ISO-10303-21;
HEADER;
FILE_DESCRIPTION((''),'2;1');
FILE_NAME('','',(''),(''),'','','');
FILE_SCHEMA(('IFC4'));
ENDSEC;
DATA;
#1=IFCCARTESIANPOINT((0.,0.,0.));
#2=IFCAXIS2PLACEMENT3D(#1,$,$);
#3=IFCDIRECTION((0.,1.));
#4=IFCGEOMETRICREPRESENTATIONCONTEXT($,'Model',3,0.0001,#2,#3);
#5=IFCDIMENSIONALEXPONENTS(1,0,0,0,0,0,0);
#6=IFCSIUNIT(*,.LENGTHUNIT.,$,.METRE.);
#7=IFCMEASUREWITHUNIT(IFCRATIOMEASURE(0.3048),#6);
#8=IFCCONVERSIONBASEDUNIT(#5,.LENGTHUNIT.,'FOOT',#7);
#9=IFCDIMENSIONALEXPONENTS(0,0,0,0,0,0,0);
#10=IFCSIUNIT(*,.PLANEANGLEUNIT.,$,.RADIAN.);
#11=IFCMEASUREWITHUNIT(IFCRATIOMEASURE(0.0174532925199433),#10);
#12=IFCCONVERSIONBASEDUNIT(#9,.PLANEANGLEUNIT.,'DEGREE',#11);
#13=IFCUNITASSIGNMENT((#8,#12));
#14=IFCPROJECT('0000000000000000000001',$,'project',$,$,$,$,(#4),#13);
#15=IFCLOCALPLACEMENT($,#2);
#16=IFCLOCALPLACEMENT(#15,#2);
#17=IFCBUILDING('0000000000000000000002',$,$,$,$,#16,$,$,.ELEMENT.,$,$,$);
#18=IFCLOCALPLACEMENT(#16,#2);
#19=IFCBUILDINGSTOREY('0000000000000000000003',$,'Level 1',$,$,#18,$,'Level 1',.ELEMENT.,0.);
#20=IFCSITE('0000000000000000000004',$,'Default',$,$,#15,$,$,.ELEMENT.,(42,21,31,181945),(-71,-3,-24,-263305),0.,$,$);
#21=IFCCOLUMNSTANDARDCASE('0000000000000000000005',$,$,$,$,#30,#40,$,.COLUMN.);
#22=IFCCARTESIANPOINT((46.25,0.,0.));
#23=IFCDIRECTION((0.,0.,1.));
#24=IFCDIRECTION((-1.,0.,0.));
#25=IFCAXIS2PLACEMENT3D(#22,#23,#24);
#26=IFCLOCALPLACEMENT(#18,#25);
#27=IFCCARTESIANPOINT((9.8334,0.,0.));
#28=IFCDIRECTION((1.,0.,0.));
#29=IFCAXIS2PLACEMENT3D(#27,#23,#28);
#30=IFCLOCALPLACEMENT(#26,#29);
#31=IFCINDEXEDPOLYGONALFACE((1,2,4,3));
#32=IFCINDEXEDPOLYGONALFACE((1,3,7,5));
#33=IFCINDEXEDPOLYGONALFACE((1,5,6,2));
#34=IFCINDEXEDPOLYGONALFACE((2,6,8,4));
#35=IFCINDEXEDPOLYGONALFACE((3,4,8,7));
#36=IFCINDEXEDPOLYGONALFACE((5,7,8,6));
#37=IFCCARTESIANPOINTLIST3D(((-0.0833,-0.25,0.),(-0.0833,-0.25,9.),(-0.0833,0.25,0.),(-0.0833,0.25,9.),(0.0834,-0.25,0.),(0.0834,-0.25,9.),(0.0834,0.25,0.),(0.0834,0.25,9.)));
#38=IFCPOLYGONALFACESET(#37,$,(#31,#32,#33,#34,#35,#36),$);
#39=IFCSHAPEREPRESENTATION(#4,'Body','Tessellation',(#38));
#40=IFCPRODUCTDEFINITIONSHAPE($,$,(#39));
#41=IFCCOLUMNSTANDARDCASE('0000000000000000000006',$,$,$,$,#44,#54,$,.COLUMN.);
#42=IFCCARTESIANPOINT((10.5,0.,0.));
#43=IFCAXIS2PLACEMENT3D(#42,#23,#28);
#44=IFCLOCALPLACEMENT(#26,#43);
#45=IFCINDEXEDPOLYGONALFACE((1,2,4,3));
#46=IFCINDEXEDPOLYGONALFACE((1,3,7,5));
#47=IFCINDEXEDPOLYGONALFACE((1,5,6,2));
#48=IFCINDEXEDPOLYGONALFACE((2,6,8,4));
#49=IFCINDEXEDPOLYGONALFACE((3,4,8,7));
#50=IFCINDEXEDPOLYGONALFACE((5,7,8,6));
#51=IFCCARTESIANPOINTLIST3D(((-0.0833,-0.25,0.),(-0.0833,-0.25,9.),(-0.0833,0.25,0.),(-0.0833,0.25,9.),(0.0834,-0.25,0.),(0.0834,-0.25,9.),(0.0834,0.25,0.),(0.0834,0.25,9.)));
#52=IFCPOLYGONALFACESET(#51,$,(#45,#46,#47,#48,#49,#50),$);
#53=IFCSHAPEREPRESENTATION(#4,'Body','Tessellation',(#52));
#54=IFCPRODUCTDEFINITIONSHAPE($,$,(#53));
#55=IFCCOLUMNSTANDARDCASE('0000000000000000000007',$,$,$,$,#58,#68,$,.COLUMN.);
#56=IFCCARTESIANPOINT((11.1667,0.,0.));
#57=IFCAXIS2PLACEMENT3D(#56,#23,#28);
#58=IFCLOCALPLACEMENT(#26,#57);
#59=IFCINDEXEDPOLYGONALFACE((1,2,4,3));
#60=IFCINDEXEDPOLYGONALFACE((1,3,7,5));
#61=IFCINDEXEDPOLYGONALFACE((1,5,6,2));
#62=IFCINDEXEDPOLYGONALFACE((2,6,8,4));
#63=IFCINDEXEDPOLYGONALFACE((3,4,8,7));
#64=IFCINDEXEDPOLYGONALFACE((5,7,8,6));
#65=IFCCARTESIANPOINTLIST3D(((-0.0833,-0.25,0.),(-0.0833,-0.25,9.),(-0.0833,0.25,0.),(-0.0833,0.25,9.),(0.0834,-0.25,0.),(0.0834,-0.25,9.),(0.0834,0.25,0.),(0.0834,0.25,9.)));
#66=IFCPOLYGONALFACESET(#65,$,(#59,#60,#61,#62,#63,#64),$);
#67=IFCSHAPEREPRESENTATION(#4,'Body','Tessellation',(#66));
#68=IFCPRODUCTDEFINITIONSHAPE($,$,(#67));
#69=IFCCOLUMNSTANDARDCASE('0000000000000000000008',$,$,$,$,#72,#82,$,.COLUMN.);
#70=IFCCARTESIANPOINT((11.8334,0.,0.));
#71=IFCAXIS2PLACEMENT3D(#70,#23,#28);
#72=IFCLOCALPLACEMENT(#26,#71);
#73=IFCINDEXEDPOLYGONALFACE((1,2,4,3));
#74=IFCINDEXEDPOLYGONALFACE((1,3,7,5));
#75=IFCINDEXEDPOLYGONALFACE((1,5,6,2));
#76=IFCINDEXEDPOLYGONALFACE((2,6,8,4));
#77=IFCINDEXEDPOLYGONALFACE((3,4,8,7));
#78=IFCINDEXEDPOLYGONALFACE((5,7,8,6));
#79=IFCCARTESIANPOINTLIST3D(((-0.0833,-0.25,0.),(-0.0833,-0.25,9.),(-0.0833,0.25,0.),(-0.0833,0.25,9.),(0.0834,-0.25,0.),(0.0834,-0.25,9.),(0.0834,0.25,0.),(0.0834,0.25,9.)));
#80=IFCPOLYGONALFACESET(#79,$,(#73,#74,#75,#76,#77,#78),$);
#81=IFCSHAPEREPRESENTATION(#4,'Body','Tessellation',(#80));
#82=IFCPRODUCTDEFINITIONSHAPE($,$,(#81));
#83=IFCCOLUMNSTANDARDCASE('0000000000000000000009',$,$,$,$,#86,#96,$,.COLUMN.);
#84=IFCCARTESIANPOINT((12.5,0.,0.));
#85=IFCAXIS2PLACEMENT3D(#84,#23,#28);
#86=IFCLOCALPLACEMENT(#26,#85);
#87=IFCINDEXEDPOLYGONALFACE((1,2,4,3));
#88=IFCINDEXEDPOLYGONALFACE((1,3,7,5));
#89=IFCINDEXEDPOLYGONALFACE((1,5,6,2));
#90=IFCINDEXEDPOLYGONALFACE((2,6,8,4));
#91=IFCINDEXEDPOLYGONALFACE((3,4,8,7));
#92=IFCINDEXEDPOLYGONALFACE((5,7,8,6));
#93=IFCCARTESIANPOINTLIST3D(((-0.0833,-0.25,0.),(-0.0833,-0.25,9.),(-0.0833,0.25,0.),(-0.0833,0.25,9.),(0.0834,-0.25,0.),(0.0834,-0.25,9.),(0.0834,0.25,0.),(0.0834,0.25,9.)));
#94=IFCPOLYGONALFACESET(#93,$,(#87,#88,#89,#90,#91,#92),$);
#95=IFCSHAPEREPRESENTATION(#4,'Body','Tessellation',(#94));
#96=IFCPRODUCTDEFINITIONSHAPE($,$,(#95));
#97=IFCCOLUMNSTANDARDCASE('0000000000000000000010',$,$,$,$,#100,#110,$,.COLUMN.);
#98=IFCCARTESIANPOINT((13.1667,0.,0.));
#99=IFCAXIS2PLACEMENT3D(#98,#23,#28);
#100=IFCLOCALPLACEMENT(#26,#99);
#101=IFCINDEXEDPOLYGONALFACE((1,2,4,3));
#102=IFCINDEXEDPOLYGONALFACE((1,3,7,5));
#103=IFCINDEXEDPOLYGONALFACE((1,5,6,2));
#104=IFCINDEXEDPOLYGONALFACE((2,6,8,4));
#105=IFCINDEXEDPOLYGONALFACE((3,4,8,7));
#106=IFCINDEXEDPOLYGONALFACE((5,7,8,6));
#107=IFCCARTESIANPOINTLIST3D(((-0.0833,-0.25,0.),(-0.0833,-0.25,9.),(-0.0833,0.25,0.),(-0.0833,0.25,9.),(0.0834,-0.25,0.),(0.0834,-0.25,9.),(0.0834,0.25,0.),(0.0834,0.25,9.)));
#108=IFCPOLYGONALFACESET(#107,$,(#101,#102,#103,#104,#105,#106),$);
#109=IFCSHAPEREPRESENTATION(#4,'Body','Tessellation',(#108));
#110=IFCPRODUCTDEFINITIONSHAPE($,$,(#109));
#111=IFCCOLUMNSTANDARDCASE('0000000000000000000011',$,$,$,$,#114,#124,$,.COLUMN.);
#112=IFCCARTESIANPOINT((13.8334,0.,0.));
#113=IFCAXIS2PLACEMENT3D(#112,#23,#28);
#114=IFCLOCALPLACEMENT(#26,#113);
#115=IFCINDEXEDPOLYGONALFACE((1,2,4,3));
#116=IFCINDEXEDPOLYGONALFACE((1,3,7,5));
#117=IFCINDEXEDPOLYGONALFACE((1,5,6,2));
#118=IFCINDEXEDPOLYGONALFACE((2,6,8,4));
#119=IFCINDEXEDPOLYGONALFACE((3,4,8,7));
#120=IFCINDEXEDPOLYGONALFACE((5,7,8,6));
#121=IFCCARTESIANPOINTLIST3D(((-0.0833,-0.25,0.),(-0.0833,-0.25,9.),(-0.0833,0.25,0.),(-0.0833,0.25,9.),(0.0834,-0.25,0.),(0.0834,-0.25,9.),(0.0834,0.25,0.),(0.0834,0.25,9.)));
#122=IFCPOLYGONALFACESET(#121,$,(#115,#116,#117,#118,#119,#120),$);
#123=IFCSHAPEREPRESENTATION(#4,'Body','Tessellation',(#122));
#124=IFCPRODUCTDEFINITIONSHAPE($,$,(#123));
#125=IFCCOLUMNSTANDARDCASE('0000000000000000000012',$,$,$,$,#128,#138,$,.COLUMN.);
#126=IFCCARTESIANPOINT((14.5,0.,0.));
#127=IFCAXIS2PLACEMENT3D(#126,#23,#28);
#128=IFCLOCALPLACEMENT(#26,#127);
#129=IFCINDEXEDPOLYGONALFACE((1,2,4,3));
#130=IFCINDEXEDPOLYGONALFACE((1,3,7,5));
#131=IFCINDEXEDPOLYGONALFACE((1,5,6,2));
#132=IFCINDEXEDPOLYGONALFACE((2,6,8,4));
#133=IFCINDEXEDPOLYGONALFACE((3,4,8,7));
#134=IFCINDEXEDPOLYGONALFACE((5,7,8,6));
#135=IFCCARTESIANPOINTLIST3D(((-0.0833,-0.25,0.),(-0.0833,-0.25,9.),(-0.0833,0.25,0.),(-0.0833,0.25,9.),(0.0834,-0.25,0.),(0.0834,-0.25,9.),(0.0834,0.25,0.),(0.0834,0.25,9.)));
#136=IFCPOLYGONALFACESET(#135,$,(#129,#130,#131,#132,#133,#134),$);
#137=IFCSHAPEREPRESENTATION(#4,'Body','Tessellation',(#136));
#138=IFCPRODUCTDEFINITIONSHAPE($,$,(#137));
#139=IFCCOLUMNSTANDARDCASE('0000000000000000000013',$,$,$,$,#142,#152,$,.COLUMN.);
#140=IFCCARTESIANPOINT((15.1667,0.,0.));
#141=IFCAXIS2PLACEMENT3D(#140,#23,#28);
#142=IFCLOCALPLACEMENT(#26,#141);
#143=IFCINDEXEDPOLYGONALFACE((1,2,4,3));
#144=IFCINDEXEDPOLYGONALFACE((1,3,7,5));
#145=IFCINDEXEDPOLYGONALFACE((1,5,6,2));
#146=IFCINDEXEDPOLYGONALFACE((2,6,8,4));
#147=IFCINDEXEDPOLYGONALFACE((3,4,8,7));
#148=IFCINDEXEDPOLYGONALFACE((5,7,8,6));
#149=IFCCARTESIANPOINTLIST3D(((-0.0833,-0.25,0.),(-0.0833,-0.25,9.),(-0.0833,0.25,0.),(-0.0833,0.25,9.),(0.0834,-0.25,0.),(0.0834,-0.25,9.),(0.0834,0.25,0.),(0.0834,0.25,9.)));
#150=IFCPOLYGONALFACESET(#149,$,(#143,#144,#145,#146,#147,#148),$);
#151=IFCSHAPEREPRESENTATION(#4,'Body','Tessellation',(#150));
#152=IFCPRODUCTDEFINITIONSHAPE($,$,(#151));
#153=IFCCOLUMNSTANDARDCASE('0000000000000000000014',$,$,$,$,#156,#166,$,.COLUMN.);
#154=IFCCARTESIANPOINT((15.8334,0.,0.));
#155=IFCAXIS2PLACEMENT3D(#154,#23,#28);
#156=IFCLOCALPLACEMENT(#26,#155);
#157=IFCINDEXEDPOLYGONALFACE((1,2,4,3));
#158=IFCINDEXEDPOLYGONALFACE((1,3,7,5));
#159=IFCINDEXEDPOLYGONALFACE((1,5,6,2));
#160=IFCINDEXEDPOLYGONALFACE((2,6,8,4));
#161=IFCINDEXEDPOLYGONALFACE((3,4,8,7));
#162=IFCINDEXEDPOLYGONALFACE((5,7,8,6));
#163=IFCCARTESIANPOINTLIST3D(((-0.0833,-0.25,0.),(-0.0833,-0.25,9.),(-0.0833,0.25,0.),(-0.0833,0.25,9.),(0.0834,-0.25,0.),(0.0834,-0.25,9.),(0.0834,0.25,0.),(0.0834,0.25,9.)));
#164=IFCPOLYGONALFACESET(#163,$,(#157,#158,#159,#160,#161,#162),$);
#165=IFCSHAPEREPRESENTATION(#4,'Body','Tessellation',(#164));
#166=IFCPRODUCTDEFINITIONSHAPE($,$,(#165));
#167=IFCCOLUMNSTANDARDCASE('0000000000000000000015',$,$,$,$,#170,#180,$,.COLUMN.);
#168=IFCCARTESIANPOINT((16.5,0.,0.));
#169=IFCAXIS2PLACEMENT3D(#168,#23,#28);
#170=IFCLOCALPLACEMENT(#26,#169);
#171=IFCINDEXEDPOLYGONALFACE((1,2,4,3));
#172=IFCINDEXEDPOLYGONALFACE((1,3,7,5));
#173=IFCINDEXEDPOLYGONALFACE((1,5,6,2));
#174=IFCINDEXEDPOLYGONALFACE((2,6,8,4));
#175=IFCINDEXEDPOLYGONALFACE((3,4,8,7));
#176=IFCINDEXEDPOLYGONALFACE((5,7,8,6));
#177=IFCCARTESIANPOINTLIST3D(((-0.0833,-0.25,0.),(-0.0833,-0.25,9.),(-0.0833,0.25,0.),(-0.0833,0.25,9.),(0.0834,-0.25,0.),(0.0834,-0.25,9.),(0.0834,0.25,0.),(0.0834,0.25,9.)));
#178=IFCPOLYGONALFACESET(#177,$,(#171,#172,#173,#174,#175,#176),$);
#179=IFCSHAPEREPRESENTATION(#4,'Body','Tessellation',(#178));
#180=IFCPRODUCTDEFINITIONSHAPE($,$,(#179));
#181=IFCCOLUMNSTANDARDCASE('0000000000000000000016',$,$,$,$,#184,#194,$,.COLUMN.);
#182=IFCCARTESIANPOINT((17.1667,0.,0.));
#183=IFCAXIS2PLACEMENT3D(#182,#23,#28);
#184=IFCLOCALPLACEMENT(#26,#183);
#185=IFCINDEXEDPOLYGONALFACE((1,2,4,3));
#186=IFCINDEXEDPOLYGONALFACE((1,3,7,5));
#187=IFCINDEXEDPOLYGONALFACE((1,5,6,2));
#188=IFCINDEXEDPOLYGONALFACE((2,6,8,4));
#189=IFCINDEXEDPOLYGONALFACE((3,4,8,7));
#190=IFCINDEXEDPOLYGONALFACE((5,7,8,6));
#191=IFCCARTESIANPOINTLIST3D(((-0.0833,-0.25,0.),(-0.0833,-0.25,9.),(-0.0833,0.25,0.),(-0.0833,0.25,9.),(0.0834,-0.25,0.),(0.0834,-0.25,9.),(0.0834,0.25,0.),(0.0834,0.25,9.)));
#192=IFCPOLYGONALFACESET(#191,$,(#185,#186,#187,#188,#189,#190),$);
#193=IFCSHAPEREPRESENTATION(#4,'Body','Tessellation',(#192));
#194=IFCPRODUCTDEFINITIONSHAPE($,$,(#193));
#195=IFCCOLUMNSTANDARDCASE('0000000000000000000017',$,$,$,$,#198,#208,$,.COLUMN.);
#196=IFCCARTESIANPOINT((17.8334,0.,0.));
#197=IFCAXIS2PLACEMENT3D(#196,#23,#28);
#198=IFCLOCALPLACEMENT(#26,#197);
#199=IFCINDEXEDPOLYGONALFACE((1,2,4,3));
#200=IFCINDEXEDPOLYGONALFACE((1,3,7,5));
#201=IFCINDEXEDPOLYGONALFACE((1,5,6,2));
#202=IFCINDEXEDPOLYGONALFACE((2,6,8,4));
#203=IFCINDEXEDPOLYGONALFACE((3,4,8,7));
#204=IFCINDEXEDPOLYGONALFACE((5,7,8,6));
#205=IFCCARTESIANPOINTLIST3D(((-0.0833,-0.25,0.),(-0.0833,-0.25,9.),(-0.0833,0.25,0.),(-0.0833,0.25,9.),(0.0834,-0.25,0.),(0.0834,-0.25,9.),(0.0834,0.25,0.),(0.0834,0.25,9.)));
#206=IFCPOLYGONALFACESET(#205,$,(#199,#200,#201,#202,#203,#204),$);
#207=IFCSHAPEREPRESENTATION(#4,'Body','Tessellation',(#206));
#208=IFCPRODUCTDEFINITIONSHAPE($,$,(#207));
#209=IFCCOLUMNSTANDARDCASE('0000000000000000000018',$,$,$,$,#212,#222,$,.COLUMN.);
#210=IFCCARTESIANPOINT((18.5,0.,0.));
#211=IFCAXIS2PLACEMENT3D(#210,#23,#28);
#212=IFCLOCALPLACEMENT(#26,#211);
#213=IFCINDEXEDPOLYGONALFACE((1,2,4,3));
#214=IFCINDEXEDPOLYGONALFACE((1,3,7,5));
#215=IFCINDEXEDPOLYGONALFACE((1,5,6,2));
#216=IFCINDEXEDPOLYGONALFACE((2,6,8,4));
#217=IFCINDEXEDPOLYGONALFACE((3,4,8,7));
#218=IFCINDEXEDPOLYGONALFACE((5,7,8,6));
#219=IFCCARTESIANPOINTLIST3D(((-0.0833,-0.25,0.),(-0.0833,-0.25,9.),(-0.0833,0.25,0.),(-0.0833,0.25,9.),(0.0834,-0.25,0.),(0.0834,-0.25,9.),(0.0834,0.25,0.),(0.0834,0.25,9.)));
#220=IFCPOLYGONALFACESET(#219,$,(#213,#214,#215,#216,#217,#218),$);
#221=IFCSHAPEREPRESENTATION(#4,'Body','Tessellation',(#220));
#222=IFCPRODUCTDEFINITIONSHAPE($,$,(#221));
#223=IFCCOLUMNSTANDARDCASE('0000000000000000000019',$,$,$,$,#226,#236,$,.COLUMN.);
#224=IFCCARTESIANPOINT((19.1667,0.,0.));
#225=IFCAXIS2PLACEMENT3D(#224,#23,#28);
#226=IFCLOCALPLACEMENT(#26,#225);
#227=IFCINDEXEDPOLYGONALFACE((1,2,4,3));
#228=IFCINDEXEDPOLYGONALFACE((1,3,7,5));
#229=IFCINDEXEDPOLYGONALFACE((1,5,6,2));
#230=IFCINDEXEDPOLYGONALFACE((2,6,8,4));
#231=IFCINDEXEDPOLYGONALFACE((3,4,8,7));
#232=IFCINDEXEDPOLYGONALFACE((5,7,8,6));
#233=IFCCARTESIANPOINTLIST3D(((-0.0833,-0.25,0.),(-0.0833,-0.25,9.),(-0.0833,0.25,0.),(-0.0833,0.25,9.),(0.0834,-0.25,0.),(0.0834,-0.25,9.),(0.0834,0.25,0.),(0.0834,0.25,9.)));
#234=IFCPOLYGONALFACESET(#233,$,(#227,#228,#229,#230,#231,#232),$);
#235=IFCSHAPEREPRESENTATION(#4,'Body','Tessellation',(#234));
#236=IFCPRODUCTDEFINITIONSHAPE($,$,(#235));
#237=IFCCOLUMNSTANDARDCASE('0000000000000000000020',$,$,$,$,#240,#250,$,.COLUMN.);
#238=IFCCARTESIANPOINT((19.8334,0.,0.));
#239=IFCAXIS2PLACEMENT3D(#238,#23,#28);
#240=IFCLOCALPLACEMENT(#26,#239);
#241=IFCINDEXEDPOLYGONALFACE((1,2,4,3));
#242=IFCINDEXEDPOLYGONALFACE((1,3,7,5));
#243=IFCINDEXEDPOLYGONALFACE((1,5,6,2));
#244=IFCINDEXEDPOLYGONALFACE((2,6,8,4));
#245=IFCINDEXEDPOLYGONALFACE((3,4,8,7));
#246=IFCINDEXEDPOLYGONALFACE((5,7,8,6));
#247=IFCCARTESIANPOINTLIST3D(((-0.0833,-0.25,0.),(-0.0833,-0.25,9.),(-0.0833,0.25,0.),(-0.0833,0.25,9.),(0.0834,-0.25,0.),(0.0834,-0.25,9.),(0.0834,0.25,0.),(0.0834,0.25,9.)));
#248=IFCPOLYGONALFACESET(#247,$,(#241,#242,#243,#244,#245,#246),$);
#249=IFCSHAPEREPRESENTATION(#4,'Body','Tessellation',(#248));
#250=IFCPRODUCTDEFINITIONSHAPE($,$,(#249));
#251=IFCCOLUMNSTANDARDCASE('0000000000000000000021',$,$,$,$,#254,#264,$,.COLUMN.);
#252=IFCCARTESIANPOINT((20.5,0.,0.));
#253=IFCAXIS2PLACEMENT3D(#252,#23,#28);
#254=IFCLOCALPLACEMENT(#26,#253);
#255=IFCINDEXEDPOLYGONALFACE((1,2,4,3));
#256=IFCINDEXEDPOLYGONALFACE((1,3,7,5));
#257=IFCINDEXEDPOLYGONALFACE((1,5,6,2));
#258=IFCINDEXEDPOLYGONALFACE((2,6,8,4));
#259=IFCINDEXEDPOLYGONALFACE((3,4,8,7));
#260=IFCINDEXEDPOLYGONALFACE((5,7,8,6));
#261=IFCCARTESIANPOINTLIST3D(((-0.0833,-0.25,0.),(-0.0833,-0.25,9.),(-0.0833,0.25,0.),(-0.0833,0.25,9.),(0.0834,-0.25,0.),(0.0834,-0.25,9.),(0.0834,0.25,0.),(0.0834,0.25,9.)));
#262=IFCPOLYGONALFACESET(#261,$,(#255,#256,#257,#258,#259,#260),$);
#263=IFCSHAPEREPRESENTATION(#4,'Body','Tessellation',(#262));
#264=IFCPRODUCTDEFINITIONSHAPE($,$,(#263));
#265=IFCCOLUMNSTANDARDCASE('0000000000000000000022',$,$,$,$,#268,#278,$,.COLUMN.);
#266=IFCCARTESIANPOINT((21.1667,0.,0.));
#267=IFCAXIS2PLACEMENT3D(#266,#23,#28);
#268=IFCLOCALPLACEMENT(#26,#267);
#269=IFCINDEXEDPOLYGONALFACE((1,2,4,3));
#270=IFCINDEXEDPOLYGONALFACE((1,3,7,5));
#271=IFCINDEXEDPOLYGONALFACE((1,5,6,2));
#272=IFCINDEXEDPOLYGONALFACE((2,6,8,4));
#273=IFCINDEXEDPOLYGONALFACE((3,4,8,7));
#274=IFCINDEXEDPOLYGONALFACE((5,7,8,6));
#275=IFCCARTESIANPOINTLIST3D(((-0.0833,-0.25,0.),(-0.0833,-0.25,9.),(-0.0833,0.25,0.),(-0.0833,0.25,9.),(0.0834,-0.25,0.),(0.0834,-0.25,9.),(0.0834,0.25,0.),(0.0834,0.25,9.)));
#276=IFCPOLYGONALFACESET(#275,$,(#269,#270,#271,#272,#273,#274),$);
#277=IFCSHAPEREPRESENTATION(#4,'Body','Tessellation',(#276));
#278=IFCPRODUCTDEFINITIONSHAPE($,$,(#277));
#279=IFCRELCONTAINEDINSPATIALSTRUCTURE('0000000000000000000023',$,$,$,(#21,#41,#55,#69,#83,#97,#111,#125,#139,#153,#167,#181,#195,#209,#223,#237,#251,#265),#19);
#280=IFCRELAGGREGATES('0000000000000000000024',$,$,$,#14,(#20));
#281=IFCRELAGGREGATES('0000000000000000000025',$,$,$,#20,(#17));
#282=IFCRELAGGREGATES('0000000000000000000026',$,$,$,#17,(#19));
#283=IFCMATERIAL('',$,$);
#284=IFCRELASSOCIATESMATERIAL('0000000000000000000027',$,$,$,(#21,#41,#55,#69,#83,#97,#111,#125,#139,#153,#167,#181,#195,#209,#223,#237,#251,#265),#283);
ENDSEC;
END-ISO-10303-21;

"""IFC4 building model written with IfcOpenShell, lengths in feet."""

from ifc_helpers import new_model, entity, si_unit, converted_unit, direction, frame, origin, place, context, project, spatial, rectangle, extrude, material, element, save


model = new_model("IFC4")

# Units and contexts
model_context = context("Model", 3, precision=0.0001, world=origin(), true_north=direction((0.0, 1.0)))
ifc_project = project(units=[converted_unit("LENGTHUNIT", "FOOT", entity("IfcRatioMeasure", 0.3048), si_unit("LENGTHUNIT", "METRE"), dimensions=[1, 0, 0, 0, 0, 0, 0]), converted_unit("PLANEANGLEUNIT", "DEGREE", entity("IfcRatioMeasure", 0.0174532925199433), si_unit("PLANEANGLEUNIT", "RADIAN"), dimensions=[0, 0, 0, 0, 0, 0, 0])], contexts=[model_context])

# Site, building, storey
site_placement = place(None, origin())
site = spatial("IfcSite", under=ifc_project, at=site_placement, Name="Default", CompositionType="ELEMENT", RefLatitude=(42, 21, 31, 181945), RefLongitude=(-71, -3, -24, -263305), RefElevation=0.0)
building_placement = place(site_placement, origin())
building = spatial("IfcBuilding", under=site, at=building_placement, CompositionType="ELEMENT")
storey_placement = place(building_placement, origin())
storey = spatial("IfcBuildingStorey", under=building, at=storey_placement, Name="Level 1", LongName="Level 1", CompositionType="ELEMENT", Elevation=0.0)

# Columns
ifc_material_1 = material(Name="")
placement = place(storey_placement, frame((46.25, 0.0, 0.0), z_axis=(0.0, 0.0, 1.0), x_axis=(-1.0, 0.0, 0.0)))
for number, where, z_axis, x_axis in (
    (1, (9.8334, 0.0, 0.0), (0.0, 0.0, 1.0), (1.0, 0.0, 0.0)),
    (2, (10.5, 0.0, 0.0), (0.0, 0.0, 1.0), (1.0, 0.0, 0.0)),
    (3, (11.1667, 0.0, 0.0), (0.0, 0.0, 1.0), (1.0, 0.0, 0.0)),
    (4, (11.8334, 0.0, 0.0), (0.0, 0.0, 1.0), (1.0, 0.0, 0.0)),
    (5, (12.5, 0.0, 0.0), (0.0, 0.0, 1.0), (1.0, 0.0, 0.0)),
    (6, (13.1667, 0.0, 0.0), (0.0, 0.0, 1.0), (1.0, 0.0, 0.0)),
    (7, (13.8334, 0.0, 0.0), (0.0, 0.0, 1.0), (1.0, 0.0, 0.0)),
    (8, (14.5, 0.0, 0.0), (0.0, 0.0, 1.0), (1.0, 0.0, 0.0)),
    (9, (15.1667, 0.0, 0.0), (0.0, 0.0, 1.0), (1.0, 0.0, 0.0)),
    (10, (15.8334, 0.0, 0.0), (0.0, 0.0, 1.0), (1.0, 0.0, 0.0)),
    (11, (16.5, 0.0, 0.0), (0.0, 0.0, 1.0), (1.0, 0.0, 0.0)),
    (12, (17.1667, 0.0, 0.0), (0.0, 0.0, 1.0), (1.0, 0.0, 0.0)),
    (13, (17.8334, 0.0, 0.0), (0.0, 0.0, 1.0), (1.0, 0.0, 0.0)),
    (14, (18.5, 0.0, 0.0), (0.0, 0.0, 1.0), (1.0, 0.0, 0.0)),
    (15, (19.1667, 0.0, 0.0), (0.0, 0.0, 1.0), (1.0, 0.0, 0.0)),
    (16, (19.8334, 0.0, 0.0), (0.0, 0.0, 1.0), (1.0, 0.0, 0.0)),
    (17, (20.5, 0.0, 0.0), (0.0, 0.0, 1.0), (1.0, 0.0, 0.0)),
    (18, (21.1667, 0.0, 0.0), (0.0, 0.0, 1.0), (1.0, 0.0, 0.0)),
):
    element("IfcColumnStandardCase", number, at=place(placement, frame(where, z_axis=z_axis, x_axis=x_axis)), inside=storey, material=ifc_material_1, PredefinedType="COLUMN", context=model_context, shape_type="SweptSolid", body=[
        extrude(rectangle(XDim=0.1667, YDim=0.5), origin(), (0.0, 0.0, 1.0), 9.0),
    ])

save(model, "model.ifc")
